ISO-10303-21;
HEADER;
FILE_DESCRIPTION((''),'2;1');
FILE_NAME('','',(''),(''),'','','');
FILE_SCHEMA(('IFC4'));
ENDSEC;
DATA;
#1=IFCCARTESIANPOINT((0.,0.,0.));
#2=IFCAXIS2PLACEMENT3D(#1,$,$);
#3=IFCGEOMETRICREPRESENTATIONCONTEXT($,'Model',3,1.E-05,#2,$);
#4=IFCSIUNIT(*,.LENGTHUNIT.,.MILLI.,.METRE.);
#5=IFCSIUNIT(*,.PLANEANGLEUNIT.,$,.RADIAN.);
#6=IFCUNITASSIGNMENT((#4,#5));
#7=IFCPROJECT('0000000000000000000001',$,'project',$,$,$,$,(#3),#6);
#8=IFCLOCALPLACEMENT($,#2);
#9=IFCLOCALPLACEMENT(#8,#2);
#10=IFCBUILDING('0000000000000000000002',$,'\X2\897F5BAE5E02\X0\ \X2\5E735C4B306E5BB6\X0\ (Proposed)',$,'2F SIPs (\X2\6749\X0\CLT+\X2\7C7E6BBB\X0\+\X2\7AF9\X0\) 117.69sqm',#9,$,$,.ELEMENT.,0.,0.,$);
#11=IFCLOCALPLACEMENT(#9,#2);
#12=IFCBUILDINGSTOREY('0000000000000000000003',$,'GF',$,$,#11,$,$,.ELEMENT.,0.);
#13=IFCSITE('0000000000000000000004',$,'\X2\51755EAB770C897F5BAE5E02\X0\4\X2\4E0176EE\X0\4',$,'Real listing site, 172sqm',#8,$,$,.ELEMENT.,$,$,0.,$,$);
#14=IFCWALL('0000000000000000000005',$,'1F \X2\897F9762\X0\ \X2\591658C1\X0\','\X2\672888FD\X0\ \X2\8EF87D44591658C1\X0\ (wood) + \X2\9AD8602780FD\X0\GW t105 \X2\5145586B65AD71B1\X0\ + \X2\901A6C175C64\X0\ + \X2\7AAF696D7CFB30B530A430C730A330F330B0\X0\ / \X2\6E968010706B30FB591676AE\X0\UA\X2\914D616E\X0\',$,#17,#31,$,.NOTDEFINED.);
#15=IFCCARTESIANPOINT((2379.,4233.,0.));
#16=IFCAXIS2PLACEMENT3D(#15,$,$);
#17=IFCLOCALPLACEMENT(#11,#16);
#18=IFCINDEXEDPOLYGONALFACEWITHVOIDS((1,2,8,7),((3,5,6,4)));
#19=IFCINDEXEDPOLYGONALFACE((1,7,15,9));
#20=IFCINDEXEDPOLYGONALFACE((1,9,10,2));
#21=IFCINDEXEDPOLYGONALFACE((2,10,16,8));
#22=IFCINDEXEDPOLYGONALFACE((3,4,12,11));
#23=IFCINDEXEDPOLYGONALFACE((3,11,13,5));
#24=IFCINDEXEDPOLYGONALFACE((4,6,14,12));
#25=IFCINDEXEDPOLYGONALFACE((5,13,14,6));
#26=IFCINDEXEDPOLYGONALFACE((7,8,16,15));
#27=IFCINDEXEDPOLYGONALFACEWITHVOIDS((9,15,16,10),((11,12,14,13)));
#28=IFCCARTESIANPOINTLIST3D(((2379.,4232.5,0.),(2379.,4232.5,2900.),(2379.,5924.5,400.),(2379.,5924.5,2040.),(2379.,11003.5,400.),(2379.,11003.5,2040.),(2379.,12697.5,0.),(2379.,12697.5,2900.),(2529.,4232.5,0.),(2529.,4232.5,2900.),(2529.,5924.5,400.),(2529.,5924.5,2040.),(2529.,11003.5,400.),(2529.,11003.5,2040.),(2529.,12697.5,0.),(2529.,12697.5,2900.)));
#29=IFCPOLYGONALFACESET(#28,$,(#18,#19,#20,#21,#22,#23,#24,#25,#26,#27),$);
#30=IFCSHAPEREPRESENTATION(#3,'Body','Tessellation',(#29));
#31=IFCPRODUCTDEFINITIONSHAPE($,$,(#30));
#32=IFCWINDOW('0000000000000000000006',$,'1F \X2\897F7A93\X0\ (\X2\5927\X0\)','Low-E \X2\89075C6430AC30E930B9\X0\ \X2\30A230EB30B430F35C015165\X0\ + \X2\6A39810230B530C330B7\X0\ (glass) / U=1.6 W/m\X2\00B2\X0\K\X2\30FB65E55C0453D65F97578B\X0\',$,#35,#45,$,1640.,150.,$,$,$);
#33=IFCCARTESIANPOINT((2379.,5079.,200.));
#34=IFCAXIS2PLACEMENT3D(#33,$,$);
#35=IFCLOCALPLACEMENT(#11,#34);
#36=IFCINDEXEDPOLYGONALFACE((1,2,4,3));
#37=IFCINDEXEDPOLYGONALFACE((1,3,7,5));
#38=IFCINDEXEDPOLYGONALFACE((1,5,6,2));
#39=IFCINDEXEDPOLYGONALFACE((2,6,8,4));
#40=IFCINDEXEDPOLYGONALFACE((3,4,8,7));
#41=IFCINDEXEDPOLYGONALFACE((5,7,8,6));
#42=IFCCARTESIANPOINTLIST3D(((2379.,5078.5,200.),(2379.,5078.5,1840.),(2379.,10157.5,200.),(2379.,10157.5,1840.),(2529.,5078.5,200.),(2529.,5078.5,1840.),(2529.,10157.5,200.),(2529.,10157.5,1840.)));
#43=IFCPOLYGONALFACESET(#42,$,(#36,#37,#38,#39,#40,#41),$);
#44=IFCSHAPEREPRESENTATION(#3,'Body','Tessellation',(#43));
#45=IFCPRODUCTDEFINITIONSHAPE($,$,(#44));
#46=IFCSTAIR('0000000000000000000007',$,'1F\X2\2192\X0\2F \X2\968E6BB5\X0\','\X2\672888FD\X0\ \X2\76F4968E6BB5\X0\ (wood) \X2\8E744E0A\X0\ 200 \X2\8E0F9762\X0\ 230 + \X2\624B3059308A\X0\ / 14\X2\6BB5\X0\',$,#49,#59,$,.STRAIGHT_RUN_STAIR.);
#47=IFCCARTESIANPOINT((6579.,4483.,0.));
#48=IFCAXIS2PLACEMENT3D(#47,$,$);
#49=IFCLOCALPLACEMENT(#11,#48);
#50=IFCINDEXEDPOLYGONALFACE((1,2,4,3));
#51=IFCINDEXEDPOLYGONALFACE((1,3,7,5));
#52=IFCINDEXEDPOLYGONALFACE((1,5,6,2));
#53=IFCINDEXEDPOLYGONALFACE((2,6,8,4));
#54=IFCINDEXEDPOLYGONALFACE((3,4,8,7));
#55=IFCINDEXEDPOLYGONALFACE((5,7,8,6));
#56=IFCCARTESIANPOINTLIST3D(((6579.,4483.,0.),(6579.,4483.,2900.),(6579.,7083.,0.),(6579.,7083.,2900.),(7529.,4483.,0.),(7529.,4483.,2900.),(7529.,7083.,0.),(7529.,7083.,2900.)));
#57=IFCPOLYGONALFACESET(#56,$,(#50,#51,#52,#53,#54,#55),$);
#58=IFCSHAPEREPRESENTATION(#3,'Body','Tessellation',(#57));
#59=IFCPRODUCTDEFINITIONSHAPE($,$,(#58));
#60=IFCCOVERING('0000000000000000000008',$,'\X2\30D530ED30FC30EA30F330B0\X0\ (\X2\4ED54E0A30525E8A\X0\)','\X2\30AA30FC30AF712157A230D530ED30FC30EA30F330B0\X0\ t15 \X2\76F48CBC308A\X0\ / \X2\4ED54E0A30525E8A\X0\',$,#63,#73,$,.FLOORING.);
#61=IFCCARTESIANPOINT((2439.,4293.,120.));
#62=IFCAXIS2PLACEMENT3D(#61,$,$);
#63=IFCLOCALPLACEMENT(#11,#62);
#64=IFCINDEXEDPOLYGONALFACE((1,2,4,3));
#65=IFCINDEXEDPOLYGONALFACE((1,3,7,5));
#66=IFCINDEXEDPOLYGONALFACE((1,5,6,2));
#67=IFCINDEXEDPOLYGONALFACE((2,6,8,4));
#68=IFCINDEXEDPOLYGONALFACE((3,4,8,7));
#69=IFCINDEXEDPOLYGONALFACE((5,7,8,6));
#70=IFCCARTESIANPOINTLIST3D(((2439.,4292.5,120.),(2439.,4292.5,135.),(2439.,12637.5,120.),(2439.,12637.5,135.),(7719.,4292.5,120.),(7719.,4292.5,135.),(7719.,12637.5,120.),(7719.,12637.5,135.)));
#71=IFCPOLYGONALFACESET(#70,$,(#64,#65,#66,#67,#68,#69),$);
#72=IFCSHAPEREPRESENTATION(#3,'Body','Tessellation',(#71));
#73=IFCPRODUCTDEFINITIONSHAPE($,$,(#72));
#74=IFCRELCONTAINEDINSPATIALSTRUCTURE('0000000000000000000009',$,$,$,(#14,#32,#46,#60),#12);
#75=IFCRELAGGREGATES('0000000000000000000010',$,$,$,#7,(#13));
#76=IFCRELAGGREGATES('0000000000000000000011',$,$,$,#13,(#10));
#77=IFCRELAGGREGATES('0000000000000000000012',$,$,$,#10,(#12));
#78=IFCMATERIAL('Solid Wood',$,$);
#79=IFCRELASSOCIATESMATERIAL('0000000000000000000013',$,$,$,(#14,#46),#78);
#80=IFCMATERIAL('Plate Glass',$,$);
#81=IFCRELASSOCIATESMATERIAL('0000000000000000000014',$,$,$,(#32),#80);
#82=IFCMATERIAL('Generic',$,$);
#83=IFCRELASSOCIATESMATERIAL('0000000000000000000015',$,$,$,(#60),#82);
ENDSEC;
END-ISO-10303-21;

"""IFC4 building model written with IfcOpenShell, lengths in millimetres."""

from ifc_helpers import new_model, si_unit, frame, frame_2d, origin, place, context, project, spatial, rectangle, extrude, material, element, fill, save


model = new_model("IFC4")

# Units and contexts
model_context = context("Model", 3, precision=1e-05, world=origin())
ifc_project = project(units=[si_unit("LENGTHUNIT", "METRE", prefix="MILLI"), si_unit("PLANEANGLEUNIT", "RADIAN")], contexts=[model_context])

# Site, building, storey
site_placement = place(None, origin())
site = spatial("IfcSite", under=ifc_project, at=site_placement, Name="兵庫県西宮市4丁目4", ObjectType="Real listing site, 172sqm", CompositionType="ELEMENT", RefElevation=0.0)
building_placement = place(site_placement, origin())
building = spatial("IfcBuilding", under=site, at=building_placement, Name="西宮市 平屋の家 (Proposed)", ObjectType="2F SIPs (杉CLT+籾殻+竹) 117.69sqm", CompositionType="ELEMENT", ElevationOfRefHeight=0.0, ElevationOfTerrain=0.0)
storey_placement = place(building_placement, origin())
storey = spatial("IfcBuildingStorey", under=building, at=storey_placement, Name="GF", CompositionType="ELEMENT", Elevation=0.0)

# Shared definitions
ifc_material_1 = material(Name="Solid Wood")
ifc_material_2 = material(Name="Generic")

# Shared definitions
ifc_material_3 = material(Name="Plate Glass")

# Wall, opening, window
wall_1_placement = place(storey_placement, frame((2379.0, 4233.0, 0.0)))
wall_1 = element("IfcWall", 1, at=wall_1_placement, inside=storey, material=ifc_material_1, Name="1F 西面 外壁", Description="木製 軸組外壁 (wood) + 高性能GW t105 充填断熱 + 通気層 + 窯業系サイディング / 準耐火・外皮UA配慮", PredefinedType="NOTDEFINED", context=model_context, shape_type="SweptSolid", body=[
    extrude(rectangle(XDim=150.0, YDim=8465.0, at=frame_2d((75.0, 4232.0))), frame((2379.0, 4233.0, 0.0)), (0.0, 0.0, 1.0), 2900.0),
])
opening_1_placement = place(storey_placement, frame((2379.0, 5079.0, 200.0)))
opening_1 = element("IfcOpeningElement", 2, at=opening_1_placement, cuts=wall_1, PredefinedType="NOTDEFINED", context=model_context, shape_type="SweptSolid", body=[
    extrude(rectangle(XDim=150.0, YDim=5079.0, at=frame_2d((75.0, 2539.0))), frame((2379.0, 5079.0, 200.0)), (0.0, 0.0, 1.0), 1640.0),
])
window_1_placement = place(storey_placement, frame((2379.0, 5079.0, 200.0)))
window_1 = element("IfcWindow", 3, at=window_1_placement, inside=storey, material=ifc_material_3, Name="1F 西窓 (大)", Description="Low-E 複層ガラス アルゴン封入 + 樹脂サッシ (glass) / U=1.6 W/m²K・日射取得型", OverallHeight=1640.0, OverallWidth=150.0, context=model_context, shape_type="SweptSolid", body=[
    extrude(rectangle(XDim=150.0, YDim=5079.0, at=frame_2d((75.0, 2539.0))), frame((2379.0, 5079.0, 200.0)), (0.0, 0.0, 1.0), 1640.0),
])
fill(opening_1, window_1)

# Stair
stair_placement = place(storey_placement, frame((6579.0, 4483.0, 0.0)))
element("IfcStair", 4, at=stair_placement, inside=storey, material=ifc_material_1, Name="1F→2F 階段", Description="木製 直階段 (wood) 蹴上 200 踏面 230 + 手すり / 14段", PredefinedType="STRAIGHT_RUN_STAIR", context=model_context, shape_type="SweptSolid", body=[
    extrude(rectangle(XDim=950.0, YDim=2600.0, at=frame_2d((475.0, 1300.0))), frame((6579.0, 4483.0, 0.0)), (0.0, 0.0, 1.0), 2900.0),
])

# Covering
covering_placement = place(storey_placement, frame((2439.0, 4293.0, 120.0)))
element("IfcCovering", 5, at=covering_placement, inside=storey, material=ifc_material_2, Name="フローリング (仕上げ床)", Description="オーク無垢フローリング t15 直貼り / 仕上げ床", PredefinedType="FLOORING", context=model_context, shape_type="SweptSolid", body=[
    extrude(rectangle(XDim=5280.0, YDim=8345.0, at=frame_2d((2640.0, 4172.0))), frame((2439.0, 4293.0, 120.0)), (0.0, 0.0, 1.0), 15.0),
])

save(model, "model.ifc")
